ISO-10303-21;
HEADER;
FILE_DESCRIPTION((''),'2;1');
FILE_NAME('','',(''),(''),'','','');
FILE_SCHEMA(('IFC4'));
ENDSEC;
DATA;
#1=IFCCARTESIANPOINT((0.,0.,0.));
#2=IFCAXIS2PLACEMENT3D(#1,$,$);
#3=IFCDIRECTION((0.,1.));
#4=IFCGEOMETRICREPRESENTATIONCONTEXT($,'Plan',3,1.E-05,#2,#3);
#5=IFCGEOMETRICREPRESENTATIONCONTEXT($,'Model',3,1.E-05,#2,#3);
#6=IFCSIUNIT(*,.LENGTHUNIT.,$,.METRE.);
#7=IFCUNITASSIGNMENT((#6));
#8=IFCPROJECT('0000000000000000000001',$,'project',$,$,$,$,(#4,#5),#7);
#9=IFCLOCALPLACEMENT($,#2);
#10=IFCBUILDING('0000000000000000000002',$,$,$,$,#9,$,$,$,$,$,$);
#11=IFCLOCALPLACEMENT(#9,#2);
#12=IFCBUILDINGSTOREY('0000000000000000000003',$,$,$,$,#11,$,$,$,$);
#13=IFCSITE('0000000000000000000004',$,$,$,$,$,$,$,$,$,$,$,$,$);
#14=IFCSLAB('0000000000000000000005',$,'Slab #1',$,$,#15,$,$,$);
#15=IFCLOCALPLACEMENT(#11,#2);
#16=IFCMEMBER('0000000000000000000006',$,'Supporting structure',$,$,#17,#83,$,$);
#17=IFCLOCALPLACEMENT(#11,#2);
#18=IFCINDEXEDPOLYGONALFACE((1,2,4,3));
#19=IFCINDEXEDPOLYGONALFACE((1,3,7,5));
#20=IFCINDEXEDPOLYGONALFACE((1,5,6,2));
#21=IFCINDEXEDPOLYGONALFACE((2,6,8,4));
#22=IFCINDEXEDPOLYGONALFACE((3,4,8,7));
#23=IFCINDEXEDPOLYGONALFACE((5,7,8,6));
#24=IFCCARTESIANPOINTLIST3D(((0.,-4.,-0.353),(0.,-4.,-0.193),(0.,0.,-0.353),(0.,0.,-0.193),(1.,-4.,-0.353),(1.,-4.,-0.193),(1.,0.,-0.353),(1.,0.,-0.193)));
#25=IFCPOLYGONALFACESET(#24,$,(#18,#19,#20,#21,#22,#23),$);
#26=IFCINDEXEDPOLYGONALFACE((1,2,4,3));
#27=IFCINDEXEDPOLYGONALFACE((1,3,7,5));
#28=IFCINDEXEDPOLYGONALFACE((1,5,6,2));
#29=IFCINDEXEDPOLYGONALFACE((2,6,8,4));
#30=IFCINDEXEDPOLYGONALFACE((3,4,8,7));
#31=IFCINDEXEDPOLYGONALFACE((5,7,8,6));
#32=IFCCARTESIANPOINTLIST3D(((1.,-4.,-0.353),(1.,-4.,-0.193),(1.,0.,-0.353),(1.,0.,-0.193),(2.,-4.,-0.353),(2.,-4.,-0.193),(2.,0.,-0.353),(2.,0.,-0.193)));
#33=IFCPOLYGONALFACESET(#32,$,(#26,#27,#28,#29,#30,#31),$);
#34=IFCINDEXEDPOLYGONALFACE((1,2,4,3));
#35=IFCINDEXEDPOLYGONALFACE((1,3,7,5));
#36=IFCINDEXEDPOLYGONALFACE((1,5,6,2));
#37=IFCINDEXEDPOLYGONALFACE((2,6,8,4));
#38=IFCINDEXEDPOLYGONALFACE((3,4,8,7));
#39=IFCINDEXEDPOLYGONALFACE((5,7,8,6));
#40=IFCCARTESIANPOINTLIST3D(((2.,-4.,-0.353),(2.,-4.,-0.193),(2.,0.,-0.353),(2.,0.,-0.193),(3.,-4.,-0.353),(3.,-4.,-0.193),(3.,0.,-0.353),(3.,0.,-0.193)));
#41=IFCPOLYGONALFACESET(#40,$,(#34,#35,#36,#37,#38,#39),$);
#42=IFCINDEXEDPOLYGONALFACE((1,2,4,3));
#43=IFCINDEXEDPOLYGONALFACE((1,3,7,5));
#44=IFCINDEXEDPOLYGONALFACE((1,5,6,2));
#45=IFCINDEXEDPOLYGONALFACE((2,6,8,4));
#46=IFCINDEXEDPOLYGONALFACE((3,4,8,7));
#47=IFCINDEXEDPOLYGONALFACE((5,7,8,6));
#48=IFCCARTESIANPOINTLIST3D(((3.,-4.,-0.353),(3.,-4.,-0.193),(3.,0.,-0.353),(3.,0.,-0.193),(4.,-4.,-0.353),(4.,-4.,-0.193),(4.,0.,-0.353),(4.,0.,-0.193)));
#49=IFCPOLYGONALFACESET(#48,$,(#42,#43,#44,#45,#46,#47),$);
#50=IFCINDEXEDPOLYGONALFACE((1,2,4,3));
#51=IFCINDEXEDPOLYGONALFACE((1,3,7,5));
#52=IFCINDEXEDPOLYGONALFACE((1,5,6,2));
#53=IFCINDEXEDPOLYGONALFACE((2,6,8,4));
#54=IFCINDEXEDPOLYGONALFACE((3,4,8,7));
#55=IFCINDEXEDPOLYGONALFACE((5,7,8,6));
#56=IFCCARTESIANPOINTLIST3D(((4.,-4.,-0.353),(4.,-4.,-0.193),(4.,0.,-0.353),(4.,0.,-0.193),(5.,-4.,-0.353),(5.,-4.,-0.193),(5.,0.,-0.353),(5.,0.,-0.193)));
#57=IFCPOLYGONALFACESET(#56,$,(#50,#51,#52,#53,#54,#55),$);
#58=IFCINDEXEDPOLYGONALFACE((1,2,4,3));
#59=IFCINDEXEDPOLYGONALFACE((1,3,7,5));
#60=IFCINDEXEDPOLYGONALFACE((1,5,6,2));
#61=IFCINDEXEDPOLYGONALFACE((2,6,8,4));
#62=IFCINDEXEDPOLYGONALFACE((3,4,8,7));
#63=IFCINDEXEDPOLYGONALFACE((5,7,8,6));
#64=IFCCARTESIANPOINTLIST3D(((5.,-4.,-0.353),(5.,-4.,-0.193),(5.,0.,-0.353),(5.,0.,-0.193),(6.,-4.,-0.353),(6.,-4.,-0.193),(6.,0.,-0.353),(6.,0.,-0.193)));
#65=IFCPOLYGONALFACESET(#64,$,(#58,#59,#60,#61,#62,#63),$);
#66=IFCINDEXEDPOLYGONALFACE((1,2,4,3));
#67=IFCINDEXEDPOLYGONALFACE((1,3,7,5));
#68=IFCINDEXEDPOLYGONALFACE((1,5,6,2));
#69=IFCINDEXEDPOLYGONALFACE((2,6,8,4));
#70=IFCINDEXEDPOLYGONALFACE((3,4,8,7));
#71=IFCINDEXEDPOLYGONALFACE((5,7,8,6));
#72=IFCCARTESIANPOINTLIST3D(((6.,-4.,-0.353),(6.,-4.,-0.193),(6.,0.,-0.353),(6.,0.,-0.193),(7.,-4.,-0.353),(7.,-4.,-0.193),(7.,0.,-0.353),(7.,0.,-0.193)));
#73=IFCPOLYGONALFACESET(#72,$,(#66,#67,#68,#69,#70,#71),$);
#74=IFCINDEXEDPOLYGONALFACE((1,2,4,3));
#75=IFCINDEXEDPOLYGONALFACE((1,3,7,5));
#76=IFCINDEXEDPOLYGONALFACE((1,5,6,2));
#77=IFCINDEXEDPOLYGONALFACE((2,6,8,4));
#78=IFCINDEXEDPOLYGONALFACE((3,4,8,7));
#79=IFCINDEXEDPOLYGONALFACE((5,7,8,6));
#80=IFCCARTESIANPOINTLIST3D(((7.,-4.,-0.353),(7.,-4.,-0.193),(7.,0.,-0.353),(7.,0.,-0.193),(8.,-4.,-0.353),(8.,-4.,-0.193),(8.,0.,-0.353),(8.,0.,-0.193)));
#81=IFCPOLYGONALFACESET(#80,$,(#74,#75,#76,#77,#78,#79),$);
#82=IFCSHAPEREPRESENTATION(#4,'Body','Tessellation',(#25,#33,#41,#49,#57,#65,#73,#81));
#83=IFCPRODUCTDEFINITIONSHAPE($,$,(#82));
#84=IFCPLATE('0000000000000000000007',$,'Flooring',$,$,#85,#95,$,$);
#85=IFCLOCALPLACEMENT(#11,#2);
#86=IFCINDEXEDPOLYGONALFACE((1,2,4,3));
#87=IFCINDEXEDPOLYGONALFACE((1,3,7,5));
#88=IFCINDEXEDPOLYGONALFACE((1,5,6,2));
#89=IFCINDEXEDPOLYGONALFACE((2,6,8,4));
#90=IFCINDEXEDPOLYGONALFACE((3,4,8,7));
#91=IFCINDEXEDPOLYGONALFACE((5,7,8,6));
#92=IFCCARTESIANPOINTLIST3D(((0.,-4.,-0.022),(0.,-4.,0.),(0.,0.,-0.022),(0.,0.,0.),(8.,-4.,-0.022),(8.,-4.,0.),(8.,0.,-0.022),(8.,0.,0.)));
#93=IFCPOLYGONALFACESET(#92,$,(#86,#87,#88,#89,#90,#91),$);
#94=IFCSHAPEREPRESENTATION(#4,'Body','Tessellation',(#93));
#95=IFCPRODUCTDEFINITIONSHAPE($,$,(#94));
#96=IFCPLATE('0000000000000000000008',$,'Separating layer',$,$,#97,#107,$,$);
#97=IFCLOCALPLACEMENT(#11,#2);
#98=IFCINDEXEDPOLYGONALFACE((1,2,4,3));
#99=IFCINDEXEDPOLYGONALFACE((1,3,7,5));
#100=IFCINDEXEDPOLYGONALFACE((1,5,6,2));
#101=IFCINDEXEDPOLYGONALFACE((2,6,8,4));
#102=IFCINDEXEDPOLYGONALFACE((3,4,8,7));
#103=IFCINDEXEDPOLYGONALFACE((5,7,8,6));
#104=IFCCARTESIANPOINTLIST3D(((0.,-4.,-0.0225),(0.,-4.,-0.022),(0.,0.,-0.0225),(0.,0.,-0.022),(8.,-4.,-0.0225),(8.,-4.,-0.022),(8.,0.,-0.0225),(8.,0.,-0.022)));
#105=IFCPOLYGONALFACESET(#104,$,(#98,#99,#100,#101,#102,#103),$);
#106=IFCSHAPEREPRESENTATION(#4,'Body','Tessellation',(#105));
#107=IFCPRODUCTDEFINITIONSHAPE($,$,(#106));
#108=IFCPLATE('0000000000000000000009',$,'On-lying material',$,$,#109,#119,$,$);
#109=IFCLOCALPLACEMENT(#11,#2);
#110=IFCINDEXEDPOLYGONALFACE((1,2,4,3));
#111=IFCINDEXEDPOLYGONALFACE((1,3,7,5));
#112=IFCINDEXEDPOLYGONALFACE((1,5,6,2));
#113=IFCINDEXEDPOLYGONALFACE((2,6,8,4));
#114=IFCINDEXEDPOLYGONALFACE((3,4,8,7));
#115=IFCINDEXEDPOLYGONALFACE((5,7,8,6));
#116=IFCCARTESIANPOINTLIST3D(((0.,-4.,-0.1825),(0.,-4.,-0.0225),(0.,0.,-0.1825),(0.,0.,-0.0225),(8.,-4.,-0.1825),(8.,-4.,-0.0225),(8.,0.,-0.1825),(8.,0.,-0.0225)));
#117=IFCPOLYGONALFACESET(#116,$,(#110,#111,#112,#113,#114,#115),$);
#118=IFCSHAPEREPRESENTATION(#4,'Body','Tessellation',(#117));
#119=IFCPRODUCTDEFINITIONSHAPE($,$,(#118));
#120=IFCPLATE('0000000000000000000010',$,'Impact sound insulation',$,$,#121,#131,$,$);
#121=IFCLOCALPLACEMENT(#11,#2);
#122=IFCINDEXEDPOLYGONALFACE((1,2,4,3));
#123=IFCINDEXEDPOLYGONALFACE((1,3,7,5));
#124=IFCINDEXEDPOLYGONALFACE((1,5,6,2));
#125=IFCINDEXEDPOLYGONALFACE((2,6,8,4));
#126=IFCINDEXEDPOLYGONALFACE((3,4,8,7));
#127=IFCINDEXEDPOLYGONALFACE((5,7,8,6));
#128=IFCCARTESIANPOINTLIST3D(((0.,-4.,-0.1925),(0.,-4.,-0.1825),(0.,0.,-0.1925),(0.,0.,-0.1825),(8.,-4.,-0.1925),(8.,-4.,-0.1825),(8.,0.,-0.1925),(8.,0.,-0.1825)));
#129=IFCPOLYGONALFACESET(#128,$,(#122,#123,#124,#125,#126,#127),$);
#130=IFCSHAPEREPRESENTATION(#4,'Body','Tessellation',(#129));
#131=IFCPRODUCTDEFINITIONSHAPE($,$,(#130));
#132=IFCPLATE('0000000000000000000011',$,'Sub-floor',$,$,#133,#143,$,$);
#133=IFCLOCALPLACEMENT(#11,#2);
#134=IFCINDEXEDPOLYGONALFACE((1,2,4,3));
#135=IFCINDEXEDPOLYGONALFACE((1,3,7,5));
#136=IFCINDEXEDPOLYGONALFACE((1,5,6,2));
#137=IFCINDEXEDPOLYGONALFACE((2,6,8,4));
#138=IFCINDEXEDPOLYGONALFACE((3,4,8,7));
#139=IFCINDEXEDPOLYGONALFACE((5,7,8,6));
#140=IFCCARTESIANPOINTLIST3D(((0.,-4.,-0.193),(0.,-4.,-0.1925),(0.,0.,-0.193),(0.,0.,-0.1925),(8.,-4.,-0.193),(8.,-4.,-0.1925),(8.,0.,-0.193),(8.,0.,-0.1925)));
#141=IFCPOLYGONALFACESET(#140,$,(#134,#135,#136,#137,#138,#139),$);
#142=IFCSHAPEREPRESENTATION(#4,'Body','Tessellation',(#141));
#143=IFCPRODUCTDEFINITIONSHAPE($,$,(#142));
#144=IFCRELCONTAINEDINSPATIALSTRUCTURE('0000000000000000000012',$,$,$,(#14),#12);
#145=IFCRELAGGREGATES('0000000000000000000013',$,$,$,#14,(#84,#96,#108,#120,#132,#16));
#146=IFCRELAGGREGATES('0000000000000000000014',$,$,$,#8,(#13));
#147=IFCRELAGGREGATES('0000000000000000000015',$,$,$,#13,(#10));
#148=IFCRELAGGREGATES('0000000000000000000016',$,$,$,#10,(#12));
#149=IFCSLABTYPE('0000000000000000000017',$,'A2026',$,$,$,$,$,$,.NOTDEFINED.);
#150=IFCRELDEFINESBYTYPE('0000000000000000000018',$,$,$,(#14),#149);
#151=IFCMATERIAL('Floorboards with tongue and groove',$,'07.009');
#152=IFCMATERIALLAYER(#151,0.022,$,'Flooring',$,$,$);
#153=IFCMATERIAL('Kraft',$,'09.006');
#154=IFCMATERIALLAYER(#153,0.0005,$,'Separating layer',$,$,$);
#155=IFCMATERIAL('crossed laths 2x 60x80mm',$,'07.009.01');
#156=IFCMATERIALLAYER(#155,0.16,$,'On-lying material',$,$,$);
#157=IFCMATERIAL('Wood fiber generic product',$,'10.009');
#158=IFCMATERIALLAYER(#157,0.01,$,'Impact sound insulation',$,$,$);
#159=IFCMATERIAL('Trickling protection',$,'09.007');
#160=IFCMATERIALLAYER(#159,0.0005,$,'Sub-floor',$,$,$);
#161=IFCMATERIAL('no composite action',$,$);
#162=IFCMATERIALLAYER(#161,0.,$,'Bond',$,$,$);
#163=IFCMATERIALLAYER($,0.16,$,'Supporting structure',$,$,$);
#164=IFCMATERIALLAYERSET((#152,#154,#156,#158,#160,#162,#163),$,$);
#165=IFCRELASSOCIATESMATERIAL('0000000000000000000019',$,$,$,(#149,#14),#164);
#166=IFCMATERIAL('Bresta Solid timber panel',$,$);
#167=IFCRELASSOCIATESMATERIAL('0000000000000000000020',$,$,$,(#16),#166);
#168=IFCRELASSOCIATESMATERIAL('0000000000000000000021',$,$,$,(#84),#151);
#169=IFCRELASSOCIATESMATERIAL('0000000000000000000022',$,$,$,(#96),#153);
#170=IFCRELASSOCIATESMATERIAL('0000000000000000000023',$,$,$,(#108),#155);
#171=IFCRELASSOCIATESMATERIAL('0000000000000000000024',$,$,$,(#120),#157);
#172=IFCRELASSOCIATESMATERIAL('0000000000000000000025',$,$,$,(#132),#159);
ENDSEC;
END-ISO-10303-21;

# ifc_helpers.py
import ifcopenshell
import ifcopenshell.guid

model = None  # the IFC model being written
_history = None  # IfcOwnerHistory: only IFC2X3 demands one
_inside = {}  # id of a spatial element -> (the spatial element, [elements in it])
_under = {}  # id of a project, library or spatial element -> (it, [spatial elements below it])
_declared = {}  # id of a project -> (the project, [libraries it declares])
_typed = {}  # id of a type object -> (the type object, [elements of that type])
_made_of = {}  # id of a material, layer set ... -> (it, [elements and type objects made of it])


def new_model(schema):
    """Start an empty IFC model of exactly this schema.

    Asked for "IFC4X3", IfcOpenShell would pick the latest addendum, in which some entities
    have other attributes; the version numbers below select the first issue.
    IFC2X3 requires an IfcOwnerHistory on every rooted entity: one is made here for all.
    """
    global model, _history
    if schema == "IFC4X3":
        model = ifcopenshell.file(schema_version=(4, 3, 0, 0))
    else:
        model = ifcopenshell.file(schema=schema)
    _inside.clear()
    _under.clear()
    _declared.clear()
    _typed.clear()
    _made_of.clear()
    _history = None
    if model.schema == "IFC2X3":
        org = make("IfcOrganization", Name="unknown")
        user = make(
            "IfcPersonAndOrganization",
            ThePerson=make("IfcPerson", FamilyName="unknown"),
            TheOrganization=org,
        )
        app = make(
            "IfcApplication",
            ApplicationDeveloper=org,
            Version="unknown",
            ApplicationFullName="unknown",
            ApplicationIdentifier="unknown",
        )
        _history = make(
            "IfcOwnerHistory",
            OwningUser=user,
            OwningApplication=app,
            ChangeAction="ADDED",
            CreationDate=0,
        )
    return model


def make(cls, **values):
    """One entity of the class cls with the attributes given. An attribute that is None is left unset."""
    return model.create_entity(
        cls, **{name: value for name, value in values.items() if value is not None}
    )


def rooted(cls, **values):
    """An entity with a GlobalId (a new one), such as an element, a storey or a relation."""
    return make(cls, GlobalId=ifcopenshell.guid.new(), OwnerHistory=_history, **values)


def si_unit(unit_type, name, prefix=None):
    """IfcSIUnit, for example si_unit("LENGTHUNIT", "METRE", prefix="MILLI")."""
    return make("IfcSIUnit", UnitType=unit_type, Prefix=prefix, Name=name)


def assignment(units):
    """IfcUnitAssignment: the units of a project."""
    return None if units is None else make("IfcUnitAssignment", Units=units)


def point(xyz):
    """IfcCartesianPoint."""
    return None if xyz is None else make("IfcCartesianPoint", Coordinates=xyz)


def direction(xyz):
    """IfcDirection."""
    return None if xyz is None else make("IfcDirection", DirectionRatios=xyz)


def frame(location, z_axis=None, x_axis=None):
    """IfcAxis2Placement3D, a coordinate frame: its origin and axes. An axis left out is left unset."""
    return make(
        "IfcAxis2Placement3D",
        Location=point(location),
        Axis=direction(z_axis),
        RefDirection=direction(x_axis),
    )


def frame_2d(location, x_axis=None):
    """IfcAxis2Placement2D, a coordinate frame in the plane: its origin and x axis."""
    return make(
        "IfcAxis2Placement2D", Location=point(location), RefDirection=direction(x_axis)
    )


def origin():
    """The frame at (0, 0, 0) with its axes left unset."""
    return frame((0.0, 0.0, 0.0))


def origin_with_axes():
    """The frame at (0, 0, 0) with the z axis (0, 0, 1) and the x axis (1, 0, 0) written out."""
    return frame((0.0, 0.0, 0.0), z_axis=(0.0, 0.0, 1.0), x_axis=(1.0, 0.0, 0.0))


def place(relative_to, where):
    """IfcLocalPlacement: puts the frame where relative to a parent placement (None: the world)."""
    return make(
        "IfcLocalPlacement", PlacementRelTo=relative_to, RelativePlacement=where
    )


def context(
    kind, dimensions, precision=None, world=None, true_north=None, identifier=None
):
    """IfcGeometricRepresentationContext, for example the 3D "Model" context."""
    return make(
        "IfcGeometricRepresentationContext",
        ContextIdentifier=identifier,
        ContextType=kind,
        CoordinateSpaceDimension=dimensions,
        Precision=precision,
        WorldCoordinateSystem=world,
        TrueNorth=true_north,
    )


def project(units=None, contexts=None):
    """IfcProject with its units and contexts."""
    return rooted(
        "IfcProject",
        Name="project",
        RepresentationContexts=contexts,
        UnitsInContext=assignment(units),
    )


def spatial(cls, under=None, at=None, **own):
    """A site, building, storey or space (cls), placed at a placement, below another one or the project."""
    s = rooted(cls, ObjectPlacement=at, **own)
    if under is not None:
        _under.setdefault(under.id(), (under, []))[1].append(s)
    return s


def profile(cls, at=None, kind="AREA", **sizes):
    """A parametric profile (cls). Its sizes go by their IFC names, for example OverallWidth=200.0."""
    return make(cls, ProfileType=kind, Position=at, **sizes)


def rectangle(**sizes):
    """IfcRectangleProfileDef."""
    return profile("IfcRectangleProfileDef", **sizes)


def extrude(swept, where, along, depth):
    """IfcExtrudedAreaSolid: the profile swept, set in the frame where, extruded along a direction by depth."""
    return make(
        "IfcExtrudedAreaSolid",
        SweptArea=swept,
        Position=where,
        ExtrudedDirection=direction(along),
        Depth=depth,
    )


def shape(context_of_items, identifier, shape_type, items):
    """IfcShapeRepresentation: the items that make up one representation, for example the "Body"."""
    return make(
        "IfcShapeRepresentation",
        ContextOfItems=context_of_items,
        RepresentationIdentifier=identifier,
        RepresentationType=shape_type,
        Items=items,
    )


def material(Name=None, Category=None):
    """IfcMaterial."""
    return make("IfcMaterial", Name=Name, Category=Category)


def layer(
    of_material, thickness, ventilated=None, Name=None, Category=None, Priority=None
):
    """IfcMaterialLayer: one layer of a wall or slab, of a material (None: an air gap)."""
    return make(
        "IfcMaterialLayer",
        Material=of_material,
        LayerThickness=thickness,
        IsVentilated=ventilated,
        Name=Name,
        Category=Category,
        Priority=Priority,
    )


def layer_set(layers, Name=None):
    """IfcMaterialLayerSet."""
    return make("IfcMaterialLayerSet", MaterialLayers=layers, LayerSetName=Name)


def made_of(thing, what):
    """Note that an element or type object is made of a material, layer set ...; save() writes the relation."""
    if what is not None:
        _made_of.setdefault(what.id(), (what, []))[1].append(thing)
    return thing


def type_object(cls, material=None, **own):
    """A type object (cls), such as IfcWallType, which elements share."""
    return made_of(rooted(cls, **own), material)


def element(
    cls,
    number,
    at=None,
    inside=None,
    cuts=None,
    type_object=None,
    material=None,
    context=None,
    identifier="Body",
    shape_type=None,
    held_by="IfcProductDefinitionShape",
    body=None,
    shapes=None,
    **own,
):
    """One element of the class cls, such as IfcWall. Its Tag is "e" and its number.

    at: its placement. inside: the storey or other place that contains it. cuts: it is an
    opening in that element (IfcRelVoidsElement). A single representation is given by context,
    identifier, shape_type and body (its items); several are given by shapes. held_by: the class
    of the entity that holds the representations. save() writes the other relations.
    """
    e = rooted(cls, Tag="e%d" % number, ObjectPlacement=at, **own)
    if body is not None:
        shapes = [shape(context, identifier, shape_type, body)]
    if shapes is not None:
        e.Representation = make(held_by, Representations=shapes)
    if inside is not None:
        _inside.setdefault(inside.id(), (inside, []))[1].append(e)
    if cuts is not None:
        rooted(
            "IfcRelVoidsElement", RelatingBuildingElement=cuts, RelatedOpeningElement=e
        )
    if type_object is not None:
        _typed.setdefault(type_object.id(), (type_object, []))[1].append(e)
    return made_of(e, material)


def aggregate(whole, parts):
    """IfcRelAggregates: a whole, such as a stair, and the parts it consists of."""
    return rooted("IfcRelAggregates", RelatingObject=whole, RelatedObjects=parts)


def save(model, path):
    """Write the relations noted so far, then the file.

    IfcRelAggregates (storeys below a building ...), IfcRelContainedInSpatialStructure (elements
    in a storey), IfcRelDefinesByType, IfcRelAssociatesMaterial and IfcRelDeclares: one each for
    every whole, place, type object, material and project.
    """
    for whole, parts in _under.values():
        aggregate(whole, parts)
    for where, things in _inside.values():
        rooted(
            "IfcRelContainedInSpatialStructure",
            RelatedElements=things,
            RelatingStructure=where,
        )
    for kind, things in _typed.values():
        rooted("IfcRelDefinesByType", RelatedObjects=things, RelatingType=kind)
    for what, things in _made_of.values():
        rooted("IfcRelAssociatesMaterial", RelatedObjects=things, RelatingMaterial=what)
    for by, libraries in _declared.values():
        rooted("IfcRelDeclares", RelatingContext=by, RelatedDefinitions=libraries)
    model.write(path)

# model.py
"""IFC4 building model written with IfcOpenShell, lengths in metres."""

from ifc_helpers import new_model, si_unit, direction, frame, frame_2d, origin, origin_with_axes, place, context, project, spatial, rectangle, extrude, material, layer, layer_set, type_object, element, aggregate, save


model = new_model("IFC4")

# Units and contexts
plan_context = context("Plan", 3, precision=1e-05, world=origin(), true_north=direction((0.0, 1.0)))
model_context = context("Model", 3, precision=1e-05, world=origin(), true_north=direction((0.0, 1.0)))
ifc_project = project(units=[si_unit("LENGTHUNIT", "METRE")], contexts=[plan_context, model_context])

# Site, building, storey
site = spatial("IfcSite", under=ifc_project)
building_placement = place(None, origin())
building = spatial("IfcBuilding", under=site, at=building_placement)
storey_placement = place(building_placement, origin())
storey = spatial("IfcBuildingStorey", under=building, at=storey_placement)

# Slab, member, plates
ifc_material_1 = material(Name="Floorboards with tongue and groove", Category="07.009")
ifc_layer_1 = layer(ifc_material_1, 0.022, Name="Flooring")
ifc_material_2 = material(Name="Kraft", Category="09.006")
ifc_layer_2 = layer(ifc_material_2, 0.0005, Name="Separating layer")
ifc_material_3 = material(Name="crossed laths 2x 60x80mm", Category="07.009.01")
ifc_layer_3 = layer(ifc_material_3, 0.16, Name="On-lying material")
ifc_material_4 = material(Name="Wood fiber generic product", Category="10.009")
ifc_layer_4 = layer(ifc_material_4, 0.01, Name="Impact sound insulation")
ifc_material_5 = material(Name="Trickling protection", Category="09.007")
ifc_layer_5 = layer(ifc_material_5, 0.0005, Name="Sub-floor")
ifc_material_6 = material(Name="no composite action")
ifc_layer_6 = layer(ifc_material_6, 0.0, Name="Bond")
ifc_layer_7 = layer(None, 0.16, Name="Supporting structure")
ifc_layer_set = layer_set([ifc_layer_1, ifc_layer_2, ifc_layer_3, ifc_layer_4, ifc_layer_5, ifc_layer_6, ifc_layer_7])
slab_type = type_object("IfcSlabType", Name="A2026", PredefinedType="NOTDEFINED", material=ifc_layer_set)
slab_placement = place(None, frame((0.0, 0.0, 0.0), z_axis=(0.0, 0.0, -1.0), x_axis=(1.0, 0.0, 0.0)))
slab = element("IfcSlab", 1, at=slab_placement, inside=storey, type_object=slab_type, material=ifc_layer_set, Name="Slab #1")
ifc_material_7 = material(Name="Bresta Solid timber panel")
member_placement = place(slab_placement, origin())
member = element("IfcMember", 2, at=member_placement, material=ifc_material_7, Name="Supporting structure", context=plan_context, shape_type="SweptSolid", body=[
    extrude(rectangle(XDim=1.0, YDim=0.16, at=frame_2d((0.5, 0.08), x_axis=(1.0, 0.0))), frame((0.0, 4.0, 0.193), z_axis=(0.0, -1.0, 0.0), x_axis=(1.0, 0.0, 0.0)), (0.0, 0.0, 1.0), 4.0),
    extrude(rectangle(XDim=1.0, YDim=0.16, at=frame_2d((0.5, 0.08), x_axis=(1.0, 0.0))), frame((1.0, 4.0, 0.193), z_axis=(0.0, -1.0, 0.0), x_axis=(1.0, 0.0, 0.0)), (0.0, 0.0, 1.0), 4.0),
    extrude(rectangle(XDim=1.0, YDim=0.16, at=frame_2d((0.5, 0.08), x_axis=(1.0, 0.0))), frame((2.0, 4.0, 0.193), z_axis=(0.0, -1.0, 0.0), x_axis=(1.0, 0.0, 0.0)), (0.0, 0.0, 1.0), 4.0),
    extrude(rectangle(XDim=1.0, YDim=0.16, at=frame_2d((0.5, 0.08), x_axis=(1.0, 0.0))), frame((3.0, 4.0, 0.193), z_axis=(0.0, -1.0, 0.0), x_axis=(1.0, 0.0, 0.0)), (0.0, 0.0, 1.0), 4.0),
    extrude(rectangle(XDim=1.0, YDim=0.16, at=frame_2d((0.5, 0.08), x_axis=(1.0, 0.0))), frame((4.0, 4.0, 0.193), z_axis=(0.0, -1.0, 0.0), x_axis=(1.0, 0.0, 0.0)), (0.0, 0.0, 1.0), 4.0),
    extrude(rectangle(XDim=1.0, YDim=0.16, at=frame_2d((0.5, 0.08), x_axis=(1.0, 0.0))), frame((5.0, 4.0, 0.193), z_axis=(0.0, -1.0, 0.0), x_axis=(1.0, 0.0, 0.0)), (0.0, 0.0, 1.0), 4.0),
    extrude(rectangle(XDim=1.0, YDim=0.16, at=frame_2d((0.5, 0.08), x_axis=(1.0, 0.0))), frame((6.0, 4.0, 0.193), z_axis=(0.0, -1.0, 0.0), x_axis=(1.0, 0.0, 0.0)), (0.0, 0.0, 1.0), 4.0),
    extrude(rectangle(XDim=1.0, YDim=0.16, at=frame_2d((0.5, 0.08), x_axis=(1.0, 0.0))), frame((7.0, 4.0, 0.193), z_axis=(0.0, -1.0, 0.0), x_axis=(1.0, 0.0, 0.0)), (0.0, 0.0, 1.0), 4.0),
])
plate_1_placement = place(slab_placement, origin())
plate_1 = element("IfcPlate", 3, at=plate_1_placement, material=ifc_material_1, Name="Flooring", context=plan_context, shape_type="SweptSolid", body=[
    extrude(rectangle(XDim=8.0, YDim=4.0, at=frame_2d((4.0, 2.0), x_axis=(1.0, 0.0))), origin_with_axes(), (0.0, 0.0, 1.0), 0.022),
])
plate_2_placement = place(slab_placement, origin())
plate_2 = element("IfcPlate", 4, at=plate_2_placement, material=ifc_material_2, Name="Separating layer", context=plan_context, shape_type="SweptSolid", body=[
    extrude(rectangle(XDim=8.0, YDim=4.0, at=frame_2d((4.0, 2.0), x_axis=(1.0, 0.0))), frame((0.0, 0.0, 0.022), z_axis=(0.0, 0.0, 1.0), x_axis=(1.0, 0.0, 0.0)), (0.0, 0.0, 1.0), 0.0005),
])
plate_3_placement = place(slab_placement, origin())
plate_3 = element("IfcPlate", 5, at=plate_3_placement, material=ifc_material_3, Name="On-lying material", context=plan_context, shape_type="SweptSolid", body=[
    extrude(rectangle(XDim=8.0, YDim=4.0, at=frame_2d((4.0, 2.0), x_axis=(1.0, 0.0))), frame((0.0, 0.0, 0.0225), z_axis=(0.0, 0.0, 1.0), x_axis=(1.0, 0.0, 0.0)), (0.0, 0.0, 1.0), 0.16),
])
plate_4_placement = place(slab_placement, origin())
plate_4 = element("IfcPlate", 6, at=plate_4_placement, material=ifc_material_4, Name="Impact sound insulation", context=plan_context, shape_type="SweptSolid", body=[
    extrude(rectangle(XDim=8.0, YDim=4.0, at=frame_2d((4.0, 2.0), x_axis=(1.0, 0.0))), frame((0.0, 0.0, 0.1825), z_axis=(0.0, 0.0, 1.0), x_axis=(1.0, 0.0, 0.0)), (0.0, 0.0, 1.0), 0.01),
])
plate_5_placement = place(slab_placement, origin())
plate_5 = element("IfcPlate", 7, at=plate_5_placement, material=ifc_material_5, Name="Sub-floor", context=plan_context, shape_type="SweptSolid", body=[
    extrude(rectangle(XDim=8.0, YDim=4.0, at=frame_2d((4.0, 2.0), x_axis=(1.0, 0.0))), frame((0.0, 0.0, 0.1925), z_axis=(0.0, 0.0, 1.0), x_axis=(1.0, 0.0, 0.0)), (0.0, 0.0, 1.0), 0.0005),
])
aggregate(slab, [plate_1, plate_2, plate_3, plate_4, plate_5, member])

save(model, "model.ifc")
